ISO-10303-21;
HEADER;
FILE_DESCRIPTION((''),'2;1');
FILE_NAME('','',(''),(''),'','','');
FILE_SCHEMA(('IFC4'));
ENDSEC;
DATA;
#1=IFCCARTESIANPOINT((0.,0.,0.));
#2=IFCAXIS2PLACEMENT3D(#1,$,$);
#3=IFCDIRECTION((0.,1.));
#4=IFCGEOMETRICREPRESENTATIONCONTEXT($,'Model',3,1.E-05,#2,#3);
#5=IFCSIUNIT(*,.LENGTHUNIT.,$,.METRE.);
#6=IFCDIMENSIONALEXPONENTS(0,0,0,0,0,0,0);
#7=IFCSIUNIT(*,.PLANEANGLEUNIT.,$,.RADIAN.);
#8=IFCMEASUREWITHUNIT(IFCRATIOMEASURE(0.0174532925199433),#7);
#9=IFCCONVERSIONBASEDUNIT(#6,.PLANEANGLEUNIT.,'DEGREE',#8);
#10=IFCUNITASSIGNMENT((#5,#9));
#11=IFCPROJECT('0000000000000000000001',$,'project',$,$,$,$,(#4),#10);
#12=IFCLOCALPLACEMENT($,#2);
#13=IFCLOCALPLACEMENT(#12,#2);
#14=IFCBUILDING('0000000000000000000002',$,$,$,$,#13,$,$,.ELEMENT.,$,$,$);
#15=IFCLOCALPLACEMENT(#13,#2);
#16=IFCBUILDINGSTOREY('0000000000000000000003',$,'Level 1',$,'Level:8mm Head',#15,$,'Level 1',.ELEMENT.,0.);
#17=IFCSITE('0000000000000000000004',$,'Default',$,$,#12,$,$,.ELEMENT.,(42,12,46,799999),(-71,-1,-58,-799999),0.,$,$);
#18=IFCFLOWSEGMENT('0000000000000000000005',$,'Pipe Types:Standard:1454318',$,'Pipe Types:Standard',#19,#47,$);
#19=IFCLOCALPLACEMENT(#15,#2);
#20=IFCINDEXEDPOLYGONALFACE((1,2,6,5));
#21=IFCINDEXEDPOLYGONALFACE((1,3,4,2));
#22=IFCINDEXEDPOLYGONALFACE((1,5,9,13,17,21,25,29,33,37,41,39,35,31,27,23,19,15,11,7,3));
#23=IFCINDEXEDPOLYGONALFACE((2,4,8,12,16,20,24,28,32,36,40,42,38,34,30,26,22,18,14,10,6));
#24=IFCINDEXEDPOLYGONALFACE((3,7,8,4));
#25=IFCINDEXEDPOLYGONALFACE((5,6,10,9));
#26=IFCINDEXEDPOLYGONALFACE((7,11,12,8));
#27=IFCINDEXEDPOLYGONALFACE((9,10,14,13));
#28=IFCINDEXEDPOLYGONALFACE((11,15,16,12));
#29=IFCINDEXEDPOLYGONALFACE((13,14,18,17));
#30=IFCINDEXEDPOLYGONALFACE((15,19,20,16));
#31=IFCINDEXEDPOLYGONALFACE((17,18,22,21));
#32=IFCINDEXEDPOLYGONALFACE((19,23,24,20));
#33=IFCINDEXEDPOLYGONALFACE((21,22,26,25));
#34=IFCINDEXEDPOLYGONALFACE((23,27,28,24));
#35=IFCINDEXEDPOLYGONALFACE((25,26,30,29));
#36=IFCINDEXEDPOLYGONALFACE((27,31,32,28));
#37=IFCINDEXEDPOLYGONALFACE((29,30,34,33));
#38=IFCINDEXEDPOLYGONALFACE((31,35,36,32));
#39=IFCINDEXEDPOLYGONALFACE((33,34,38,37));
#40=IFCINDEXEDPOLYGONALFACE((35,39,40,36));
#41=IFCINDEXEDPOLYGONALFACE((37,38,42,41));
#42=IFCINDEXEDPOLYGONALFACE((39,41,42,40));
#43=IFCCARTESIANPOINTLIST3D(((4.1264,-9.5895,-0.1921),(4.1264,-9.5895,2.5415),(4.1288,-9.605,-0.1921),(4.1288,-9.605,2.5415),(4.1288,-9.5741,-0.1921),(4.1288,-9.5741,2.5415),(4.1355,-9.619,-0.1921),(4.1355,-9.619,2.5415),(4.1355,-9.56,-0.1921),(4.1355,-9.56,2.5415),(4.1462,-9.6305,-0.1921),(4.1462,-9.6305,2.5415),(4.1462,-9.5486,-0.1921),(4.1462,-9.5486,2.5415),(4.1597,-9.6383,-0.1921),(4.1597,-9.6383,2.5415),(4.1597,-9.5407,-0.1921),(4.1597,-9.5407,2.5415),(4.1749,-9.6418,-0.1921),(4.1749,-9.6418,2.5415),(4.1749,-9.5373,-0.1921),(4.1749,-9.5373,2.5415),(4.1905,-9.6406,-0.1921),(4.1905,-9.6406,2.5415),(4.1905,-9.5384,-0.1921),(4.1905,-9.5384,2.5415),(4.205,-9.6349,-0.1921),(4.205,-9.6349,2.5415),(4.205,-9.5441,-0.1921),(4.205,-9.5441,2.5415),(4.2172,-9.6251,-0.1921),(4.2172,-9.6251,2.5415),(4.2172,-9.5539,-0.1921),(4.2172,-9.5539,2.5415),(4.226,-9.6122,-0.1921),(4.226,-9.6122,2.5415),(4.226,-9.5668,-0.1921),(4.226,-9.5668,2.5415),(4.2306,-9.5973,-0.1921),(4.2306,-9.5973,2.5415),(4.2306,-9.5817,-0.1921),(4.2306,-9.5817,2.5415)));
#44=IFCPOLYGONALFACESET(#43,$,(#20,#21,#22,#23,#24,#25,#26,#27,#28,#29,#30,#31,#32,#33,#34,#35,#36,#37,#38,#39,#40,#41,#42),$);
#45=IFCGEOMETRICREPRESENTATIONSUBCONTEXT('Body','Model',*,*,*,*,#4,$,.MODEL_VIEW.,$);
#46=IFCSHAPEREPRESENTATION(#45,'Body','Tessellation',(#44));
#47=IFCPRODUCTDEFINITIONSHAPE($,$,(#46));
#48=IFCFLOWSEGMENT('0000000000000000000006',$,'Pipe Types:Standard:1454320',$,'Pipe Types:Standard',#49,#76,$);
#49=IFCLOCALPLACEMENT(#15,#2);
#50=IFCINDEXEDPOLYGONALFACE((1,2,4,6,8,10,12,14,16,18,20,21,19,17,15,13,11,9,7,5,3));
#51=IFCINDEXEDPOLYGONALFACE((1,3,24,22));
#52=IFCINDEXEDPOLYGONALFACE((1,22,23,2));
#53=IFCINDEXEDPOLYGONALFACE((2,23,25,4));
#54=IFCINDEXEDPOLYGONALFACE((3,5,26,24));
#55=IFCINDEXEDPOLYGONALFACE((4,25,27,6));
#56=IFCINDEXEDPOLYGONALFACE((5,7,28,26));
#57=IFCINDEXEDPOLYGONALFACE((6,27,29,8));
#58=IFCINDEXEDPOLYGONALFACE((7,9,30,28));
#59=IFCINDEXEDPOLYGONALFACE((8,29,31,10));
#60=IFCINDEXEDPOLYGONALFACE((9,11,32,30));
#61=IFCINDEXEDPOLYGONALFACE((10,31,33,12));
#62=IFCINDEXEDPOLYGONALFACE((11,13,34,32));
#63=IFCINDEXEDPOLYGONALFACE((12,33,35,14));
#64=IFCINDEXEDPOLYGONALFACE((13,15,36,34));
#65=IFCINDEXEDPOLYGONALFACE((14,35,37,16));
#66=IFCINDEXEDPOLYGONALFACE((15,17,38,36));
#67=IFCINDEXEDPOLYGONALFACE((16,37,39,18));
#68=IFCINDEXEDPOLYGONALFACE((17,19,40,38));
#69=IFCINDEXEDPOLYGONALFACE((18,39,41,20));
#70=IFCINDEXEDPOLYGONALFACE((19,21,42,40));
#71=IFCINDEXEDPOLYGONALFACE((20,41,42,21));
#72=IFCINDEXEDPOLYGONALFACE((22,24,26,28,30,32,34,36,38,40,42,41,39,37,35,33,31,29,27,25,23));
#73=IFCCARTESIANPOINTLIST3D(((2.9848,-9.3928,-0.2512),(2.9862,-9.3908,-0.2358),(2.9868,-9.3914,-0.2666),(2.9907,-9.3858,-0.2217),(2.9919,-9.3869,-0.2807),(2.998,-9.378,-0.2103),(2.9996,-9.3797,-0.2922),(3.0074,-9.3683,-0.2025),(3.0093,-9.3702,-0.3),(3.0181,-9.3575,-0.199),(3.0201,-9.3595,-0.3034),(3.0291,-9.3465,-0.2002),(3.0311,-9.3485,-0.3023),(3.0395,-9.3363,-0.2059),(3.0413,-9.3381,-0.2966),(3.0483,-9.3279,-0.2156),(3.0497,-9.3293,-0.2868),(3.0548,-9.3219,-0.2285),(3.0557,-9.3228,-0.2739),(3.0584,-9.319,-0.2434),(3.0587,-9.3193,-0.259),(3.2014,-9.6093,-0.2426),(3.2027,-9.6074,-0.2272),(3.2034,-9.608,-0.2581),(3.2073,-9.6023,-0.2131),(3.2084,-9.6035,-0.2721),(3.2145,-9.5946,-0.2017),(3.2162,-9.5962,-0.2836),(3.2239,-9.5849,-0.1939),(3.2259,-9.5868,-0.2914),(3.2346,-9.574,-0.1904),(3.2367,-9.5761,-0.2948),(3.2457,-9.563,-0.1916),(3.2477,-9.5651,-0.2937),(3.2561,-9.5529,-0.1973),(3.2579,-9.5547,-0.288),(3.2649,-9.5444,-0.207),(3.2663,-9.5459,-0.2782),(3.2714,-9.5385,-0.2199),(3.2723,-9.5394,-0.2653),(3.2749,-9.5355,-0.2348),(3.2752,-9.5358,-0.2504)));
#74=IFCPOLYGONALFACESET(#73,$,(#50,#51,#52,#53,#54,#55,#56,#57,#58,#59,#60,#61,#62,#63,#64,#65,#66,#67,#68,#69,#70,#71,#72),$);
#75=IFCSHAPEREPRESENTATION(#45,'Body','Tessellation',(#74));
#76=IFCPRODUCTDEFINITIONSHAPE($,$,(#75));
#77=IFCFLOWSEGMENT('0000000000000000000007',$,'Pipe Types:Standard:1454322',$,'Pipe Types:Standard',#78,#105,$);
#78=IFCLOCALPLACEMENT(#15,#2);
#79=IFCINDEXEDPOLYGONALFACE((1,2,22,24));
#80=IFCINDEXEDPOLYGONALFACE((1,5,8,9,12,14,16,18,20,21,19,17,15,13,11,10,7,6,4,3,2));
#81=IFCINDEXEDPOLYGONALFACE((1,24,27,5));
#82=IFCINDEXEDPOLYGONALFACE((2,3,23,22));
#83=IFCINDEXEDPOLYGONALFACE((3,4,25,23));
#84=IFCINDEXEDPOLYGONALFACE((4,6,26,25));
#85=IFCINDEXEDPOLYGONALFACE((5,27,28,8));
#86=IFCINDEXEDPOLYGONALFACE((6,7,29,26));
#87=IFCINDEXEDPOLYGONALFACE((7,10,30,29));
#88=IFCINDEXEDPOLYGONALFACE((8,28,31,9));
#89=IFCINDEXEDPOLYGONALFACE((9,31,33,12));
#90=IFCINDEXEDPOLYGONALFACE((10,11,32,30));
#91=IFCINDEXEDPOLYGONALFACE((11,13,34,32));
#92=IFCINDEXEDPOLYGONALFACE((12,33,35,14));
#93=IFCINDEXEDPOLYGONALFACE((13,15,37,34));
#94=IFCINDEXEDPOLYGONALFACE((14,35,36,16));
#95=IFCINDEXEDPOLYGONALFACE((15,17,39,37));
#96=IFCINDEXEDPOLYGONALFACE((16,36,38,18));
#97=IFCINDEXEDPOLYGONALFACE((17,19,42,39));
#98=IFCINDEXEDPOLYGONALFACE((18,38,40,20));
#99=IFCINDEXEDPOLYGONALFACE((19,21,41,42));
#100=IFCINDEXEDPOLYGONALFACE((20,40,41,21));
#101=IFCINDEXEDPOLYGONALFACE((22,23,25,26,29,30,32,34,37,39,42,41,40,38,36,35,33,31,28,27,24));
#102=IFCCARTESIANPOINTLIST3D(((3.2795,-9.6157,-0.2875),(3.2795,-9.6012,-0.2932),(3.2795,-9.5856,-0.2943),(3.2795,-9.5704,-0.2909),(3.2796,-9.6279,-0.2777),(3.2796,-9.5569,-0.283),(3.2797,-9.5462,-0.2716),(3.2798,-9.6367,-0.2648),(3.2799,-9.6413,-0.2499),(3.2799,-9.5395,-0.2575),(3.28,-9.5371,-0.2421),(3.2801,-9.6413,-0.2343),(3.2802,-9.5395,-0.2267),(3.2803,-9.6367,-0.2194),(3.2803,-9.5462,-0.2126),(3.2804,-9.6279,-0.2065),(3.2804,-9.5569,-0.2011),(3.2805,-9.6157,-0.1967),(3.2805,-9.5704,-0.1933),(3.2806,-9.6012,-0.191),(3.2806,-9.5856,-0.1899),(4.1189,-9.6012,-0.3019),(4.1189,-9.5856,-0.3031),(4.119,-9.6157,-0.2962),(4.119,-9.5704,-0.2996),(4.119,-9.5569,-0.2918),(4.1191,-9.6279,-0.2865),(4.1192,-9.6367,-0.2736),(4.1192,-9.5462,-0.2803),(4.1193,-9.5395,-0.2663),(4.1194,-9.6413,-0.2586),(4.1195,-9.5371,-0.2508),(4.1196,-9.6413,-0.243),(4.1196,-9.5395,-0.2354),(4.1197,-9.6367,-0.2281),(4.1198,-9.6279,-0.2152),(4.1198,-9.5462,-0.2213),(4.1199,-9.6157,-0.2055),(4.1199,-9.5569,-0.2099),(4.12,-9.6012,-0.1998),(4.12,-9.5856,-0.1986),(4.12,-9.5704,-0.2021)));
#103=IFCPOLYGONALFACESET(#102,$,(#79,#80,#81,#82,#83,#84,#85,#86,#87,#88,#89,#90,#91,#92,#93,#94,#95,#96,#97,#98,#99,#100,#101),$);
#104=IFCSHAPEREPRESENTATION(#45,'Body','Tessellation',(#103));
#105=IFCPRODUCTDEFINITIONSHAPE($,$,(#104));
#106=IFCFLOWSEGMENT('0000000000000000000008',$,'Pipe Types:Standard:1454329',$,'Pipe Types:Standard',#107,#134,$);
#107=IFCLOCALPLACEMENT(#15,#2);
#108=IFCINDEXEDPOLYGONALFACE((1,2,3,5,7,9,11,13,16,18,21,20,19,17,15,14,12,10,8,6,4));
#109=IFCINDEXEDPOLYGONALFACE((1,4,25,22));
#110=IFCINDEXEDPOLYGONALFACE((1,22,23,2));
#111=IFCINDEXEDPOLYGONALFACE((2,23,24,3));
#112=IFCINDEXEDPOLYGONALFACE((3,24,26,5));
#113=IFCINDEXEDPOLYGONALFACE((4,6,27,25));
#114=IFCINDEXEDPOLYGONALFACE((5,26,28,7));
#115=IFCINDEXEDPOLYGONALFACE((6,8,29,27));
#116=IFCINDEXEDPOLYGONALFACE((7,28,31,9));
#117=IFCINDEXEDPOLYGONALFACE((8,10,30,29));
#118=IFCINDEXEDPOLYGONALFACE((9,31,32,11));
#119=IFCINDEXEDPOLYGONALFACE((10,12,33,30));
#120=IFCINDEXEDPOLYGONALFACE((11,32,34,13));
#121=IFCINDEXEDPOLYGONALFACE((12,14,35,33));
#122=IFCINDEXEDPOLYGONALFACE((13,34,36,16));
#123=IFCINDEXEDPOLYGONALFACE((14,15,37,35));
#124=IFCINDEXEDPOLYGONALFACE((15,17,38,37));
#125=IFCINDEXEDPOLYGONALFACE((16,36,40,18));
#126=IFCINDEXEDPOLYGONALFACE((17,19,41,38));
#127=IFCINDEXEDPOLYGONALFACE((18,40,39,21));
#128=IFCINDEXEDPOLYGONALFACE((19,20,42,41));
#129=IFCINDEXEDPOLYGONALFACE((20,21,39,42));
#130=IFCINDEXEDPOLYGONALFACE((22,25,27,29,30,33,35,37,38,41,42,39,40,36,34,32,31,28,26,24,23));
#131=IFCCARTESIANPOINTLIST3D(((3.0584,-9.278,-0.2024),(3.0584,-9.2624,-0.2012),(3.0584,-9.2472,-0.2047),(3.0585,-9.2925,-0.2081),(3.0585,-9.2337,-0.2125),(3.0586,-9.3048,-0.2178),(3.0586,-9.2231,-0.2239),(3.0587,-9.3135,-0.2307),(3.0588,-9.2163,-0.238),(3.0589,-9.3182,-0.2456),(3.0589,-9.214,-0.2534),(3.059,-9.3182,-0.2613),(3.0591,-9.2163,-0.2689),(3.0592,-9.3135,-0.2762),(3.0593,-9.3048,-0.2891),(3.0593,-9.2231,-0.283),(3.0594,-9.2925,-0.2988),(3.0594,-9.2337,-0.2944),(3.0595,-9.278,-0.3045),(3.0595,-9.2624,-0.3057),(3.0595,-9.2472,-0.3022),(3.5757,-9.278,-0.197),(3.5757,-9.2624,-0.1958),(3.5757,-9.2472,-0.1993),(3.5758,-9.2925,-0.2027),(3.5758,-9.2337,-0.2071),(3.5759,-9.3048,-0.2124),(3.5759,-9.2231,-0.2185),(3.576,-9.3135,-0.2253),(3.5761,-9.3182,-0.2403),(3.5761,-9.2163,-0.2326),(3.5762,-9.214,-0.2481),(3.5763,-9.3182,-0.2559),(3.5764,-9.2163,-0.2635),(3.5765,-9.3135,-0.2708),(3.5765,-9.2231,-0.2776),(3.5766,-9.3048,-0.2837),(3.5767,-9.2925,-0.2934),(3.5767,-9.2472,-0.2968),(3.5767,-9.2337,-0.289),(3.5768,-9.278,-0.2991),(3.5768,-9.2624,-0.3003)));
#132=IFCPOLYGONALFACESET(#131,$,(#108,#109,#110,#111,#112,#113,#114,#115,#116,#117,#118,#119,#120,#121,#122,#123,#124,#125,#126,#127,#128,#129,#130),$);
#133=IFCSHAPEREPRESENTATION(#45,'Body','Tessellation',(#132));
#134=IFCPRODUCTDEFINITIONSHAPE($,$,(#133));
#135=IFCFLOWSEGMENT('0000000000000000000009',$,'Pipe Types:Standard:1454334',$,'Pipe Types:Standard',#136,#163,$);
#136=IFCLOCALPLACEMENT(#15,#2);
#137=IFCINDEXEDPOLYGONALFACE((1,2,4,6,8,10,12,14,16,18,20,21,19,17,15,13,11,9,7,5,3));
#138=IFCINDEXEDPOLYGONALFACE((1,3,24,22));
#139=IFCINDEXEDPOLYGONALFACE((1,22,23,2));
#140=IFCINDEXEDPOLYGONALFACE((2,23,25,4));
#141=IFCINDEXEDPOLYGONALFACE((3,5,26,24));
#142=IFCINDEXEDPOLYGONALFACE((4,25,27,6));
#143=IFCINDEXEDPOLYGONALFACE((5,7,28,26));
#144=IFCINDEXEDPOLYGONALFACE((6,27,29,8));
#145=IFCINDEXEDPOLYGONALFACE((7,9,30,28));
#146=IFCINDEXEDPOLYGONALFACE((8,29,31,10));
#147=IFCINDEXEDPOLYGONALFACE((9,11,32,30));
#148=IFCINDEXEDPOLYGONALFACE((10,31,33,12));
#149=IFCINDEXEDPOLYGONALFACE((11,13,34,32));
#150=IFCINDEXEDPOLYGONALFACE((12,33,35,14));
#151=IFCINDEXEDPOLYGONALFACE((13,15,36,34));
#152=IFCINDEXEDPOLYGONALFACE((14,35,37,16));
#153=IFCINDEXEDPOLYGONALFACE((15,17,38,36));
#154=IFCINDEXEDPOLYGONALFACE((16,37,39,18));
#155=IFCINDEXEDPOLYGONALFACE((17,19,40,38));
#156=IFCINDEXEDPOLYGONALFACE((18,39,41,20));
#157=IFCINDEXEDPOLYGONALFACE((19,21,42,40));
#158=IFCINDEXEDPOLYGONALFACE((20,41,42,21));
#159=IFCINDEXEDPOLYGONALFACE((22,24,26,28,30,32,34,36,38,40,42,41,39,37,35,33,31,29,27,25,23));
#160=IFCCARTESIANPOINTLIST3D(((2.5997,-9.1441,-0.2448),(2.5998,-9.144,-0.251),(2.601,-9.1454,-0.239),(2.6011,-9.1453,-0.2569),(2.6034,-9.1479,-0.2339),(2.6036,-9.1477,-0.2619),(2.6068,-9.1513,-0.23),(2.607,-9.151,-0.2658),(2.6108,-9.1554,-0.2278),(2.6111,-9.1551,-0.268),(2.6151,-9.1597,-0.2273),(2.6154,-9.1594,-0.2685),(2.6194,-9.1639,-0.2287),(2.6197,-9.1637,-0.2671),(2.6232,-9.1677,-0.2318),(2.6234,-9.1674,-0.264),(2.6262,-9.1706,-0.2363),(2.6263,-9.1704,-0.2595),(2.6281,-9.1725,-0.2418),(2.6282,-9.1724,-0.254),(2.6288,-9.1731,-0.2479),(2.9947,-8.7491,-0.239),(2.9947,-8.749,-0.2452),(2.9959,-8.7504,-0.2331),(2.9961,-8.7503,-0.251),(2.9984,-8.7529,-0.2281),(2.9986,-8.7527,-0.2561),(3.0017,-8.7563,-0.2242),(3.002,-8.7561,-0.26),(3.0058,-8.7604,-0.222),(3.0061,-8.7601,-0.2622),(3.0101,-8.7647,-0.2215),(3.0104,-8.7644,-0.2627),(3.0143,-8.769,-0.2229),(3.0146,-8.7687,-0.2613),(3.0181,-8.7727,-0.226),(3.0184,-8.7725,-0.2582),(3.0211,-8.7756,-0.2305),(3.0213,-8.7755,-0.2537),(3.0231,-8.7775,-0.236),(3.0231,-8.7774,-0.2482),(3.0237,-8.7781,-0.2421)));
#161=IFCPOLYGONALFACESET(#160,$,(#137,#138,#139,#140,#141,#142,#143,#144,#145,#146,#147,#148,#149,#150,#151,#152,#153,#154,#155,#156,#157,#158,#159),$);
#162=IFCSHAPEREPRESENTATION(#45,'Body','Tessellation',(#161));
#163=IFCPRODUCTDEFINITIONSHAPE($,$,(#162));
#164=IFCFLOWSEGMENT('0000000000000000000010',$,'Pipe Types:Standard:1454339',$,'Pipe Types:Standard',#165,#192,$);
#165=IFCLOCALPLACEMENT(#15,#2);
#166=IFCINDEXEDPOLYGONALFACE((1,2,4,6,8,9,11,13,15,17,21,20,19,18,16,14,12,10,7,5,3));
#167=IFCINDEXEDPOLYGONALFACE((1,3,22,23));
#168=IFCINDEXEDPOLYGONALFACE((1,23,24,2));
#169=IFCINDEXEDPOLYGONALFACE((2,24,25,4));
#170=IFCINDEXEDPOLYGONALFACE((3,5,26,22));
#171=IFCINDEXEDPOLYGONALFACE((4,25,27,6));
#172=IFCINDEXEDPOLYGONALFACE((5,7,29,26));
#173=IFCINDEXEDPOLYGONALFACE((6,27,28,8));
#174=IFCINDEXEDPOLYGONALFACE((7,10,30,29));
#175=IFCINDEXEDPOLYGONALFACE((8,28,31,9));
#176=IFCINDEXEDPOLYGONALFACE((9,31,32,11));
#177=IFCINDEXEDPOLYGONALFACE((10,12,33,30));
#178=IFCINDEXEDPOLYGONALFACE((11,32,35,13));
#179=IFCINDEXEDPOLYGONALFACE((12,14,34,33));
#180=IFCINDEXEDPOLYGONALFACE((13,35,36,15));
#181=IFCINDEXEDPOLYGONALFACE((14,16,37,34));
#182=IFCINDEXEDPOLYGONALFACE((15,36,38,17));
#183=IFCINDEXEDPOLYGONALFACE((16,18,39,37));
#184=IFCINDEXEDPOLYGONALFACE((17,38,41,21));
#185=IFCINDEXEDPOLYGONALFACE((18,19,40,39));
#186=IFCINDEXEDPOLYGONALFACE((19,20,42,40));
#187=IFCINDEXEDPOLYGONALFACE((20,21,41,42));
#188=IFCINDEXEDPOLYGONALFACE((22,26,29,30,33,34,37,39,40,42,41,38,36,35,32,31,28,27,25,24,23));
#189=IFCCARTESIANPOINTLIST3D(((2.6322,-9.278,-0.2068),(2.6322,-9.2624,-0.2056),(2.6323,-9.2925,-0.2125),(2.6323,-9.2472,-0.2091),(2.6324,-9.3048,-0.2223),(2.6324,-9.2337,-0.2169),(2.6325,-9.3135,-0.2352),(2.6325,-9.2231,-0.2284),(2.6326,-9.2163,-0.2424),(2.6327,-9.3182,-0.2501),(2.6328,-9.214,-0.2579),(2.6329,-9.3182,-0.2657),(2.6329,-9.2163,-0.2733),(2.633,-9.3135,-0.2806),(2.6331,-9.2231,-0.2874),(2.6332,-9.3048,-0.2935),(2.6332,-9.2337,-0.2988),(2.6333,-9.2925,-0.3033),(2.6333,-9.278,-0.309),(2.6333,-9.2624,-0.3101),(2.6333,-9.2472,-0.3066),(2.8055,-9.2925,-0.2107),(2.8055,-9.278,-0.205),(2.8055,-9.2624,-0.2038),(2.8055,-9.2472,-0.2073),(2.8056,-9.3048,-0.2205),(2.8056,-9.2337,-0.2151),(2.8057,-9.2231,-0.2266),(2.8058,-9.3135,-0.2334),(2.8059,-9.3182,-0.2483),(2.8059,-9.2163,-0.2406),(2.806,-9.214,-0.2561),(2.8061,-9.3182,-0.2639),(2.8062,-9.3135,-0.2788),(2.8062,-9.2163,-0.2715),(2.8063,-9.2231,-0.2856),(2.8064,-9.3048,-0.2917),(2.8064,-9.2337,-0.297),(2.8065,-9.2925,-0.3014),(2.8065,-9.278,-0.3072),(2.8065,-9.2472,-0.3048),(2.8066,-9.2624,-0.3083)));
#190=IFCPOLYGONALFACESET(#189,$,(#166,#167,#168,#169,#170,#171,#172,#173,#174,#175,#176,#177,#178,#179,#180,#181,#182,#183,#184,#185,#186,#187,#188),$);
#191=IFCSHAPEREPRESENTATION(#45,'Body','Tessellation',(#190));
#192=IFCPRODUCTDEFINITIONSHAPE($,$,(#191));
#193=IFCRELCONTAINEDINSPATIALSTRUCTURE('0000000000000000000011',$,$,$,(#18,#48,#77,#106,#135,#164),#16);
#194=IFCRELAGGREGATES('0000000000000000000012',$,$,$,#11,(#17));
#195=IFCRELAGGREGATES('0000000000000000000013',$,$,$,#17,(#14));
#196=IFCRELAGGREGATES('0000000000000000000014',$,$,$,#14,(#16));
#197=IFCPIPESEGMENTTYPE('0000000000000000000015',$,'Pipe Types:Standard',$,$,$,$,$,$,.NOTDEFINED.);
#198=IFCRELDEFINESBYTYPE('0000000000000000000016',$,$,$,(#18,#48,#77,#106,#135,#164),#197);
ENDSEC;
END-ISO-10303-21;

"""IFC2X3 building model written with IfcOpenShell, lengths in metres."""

from ifc_helpers import new_model, entity, si_unit, converted_unit, direction, frame, frame_2d, origin, origin_2d_with_axis, place, context, subcontext, project, spatial, circle, extrude, type_object, element, save


model = new_model("IFC2X3")

# Units and contexts
model_context = context("Model", 3, precision=1e-05, world=origin(), true_north=direction((0.0, 1.0)))
body_context = subcontext(model_context, "Body", "Model", "MODEL_VIEW")
ifc_project = project(units=[si_unit("LENGTHUNIT", "METRE"), converted_unit("PLANEANGLEUNIT", "DEGREE", entity("IfcRatioMeasure", 0.0174532925199433), si_unit("PLANEANGLEUNIT", "RADIAN"), dimensions=[0, 0, 0, 0, 0, 0, 0])], contexts=[model_context])

# Site, building, storey
site_placement = place(None, origin())
site = spatial("IfcSite", under=ifc_project, at=site_placement, Name="Default", CompositionType="ELEMENT", RefLatitude=(42, 12, 46, 799999), RefLongitude=(-71, -1, -58, -799999), RefElevation=0.0)
building_placement = place(site_placement, origin())
building = spatial("IfcBuilding", under=site, at=building_placement, CompositionType="ELEMENT")
storey_placement = place(building_placement, origin())
storey = spatial("IfcBuildingStorey", under=building, at=storey_placement, Name="Level 1", ObjectType="Level:8mm Head", LongName="Level 1", CompositionType="ELEMENT", Elevation=0.0)

# Flow segments
pipe_segment_type = type_object("IfcPipeSegmentType", Name="Pipe Types:Standard", PredefinedType="NOTDEFINED")
flow_segment_1_placement = place(storey_placement, origin())
element("IfcFlowSegment", 1, at=flow_segment_1_placement, inside=storey, type_object=pipe_segment_type, Name="Pipe Types:Standard:1454318", ObjectType="Pipe Types:Standard", context=body_context, shape_type="SweptSolid", body=[
    extrude(circle(Radius=0.0524, at=origin_2d_with_axis()), frame((4.1788, -9.5895, -0.1921), z_axis=(0.0, 0.0, 1.0), x_axis=(-1.0, 0.0, 0.0)), (0.0, 0.0, 1.0), 2.7336),
])
flow_segment_2_placement = place(storey_placement, origin())
element("IfcFlowSegment", 2, at=flow_segment_2_placement, inside=storey, type_object=pipe_segment_type, Name="Pipe Types:Standard:1454320", ObjectType="Pipe Types:Standard", context=body_context, shape_type="SweptSolid", body=[
    extrude(circle(Radius=0.0524, at=frame_2d((0.0, 0.0), x_axis=(1.0, 0.0))), frame((3.0219, -9.3557, -0.2512), z_axis=(0.706847, -0.706809, 0.028066), x_axis=(-0.707088, -0.707126, 0.0)), (0.0, 0.0, 1.0), 0.3064),
])
flow_segment_3_placement = place(storey_placement, origin())
element("IfcFlowSegment", 3, at=flow_segment_3_placement, inside=storey, type_object=pipe_segment_type, Name="Pipe Types:Standard:1454322", ObjectType="Pipe Types:Standard", context=body_context, shape_type="SweptSolid", body=[
    extrude(circle(Radius=0.0524, at=frame_2d((0.0, 0.0), x_axis=(1.0, 0.0))), frame((4.1195, -9.5895, -0.2508), z_axis=(-0.999946, 0.0, 0.010416), x_axis=(0.0, 1.0, 0.0)), (0.0, 0.0, 1.0), 0.8395),
])
flow_segment_4_placement = place(storey_placement, origin())
element("IfcFlowSegment", 4, at=flow_segment_4_placement, inside=storey, type_object=pipe_segment_type, Name="Pipe Types:Standard:1454329", ObjectType="Pipe Types:Standard", context=body_context, shape_type="SweptSolid", body=[
    extrude(circle(Radius=0.0524, at=frame_2d((0.0, 0.0), x_axis=(1.0, 0.0))), frame((3.0589, -9.2664, -0.2534), z_axis=(0.999946, 0.0, 0.010416), x_axis=(0.0, 1.0, 0.0)), (0.0, 0.0, 1.0), 0.5173),
])
flow_segment_5_placement = place(storey_placement, origin())
element("IfcFlowSegment", 5, at=flow_segment_5_placement, inside=storey, type_object=pipe_segment_type, Name="Pipe Types:Standard:1454334", ObjectType="Pipe Types:Standard", context=body_context, shape_type="SweptSolid", body=[
    extrude(circle(Radius=0.0206, at=frame_2d((0.0, 0.0), x_axis=(1.0, 0.0))), frame((2.6142, -9.1585, -0.2479), z_axis=(0.707068, 0.707068, 0.010416), x_axis=(0.707107, -0.707107, 0.0)), (0.0, 0.0, 1.0), 0.5586),
])
flow_segment_6_placement = place(storey_placement, origin())
element("IfcFlowSegment", 6, at=flow_segment_6_placement, inside=storey, type_object=pipe_segment_type, Name="Pipe Types:Standard:1454339", ObjectType="Pipe Types:Standard", context=body_context, shape_type="SweptSolid", body=[
    extrude(circle(Radius=0.0524, at=frame_2d((0.0, 0.0), x_axis=(1.0, 0.0))), frame((2.6328, -9.2664, -0.2579), z_axis=(0.999946, 0.0, 0.010416), x_axis=(0.0, 1.0, 0.0)), (0.0, 0.0, 1.0), 0.1732),
])

save(model, "model.ifc")
